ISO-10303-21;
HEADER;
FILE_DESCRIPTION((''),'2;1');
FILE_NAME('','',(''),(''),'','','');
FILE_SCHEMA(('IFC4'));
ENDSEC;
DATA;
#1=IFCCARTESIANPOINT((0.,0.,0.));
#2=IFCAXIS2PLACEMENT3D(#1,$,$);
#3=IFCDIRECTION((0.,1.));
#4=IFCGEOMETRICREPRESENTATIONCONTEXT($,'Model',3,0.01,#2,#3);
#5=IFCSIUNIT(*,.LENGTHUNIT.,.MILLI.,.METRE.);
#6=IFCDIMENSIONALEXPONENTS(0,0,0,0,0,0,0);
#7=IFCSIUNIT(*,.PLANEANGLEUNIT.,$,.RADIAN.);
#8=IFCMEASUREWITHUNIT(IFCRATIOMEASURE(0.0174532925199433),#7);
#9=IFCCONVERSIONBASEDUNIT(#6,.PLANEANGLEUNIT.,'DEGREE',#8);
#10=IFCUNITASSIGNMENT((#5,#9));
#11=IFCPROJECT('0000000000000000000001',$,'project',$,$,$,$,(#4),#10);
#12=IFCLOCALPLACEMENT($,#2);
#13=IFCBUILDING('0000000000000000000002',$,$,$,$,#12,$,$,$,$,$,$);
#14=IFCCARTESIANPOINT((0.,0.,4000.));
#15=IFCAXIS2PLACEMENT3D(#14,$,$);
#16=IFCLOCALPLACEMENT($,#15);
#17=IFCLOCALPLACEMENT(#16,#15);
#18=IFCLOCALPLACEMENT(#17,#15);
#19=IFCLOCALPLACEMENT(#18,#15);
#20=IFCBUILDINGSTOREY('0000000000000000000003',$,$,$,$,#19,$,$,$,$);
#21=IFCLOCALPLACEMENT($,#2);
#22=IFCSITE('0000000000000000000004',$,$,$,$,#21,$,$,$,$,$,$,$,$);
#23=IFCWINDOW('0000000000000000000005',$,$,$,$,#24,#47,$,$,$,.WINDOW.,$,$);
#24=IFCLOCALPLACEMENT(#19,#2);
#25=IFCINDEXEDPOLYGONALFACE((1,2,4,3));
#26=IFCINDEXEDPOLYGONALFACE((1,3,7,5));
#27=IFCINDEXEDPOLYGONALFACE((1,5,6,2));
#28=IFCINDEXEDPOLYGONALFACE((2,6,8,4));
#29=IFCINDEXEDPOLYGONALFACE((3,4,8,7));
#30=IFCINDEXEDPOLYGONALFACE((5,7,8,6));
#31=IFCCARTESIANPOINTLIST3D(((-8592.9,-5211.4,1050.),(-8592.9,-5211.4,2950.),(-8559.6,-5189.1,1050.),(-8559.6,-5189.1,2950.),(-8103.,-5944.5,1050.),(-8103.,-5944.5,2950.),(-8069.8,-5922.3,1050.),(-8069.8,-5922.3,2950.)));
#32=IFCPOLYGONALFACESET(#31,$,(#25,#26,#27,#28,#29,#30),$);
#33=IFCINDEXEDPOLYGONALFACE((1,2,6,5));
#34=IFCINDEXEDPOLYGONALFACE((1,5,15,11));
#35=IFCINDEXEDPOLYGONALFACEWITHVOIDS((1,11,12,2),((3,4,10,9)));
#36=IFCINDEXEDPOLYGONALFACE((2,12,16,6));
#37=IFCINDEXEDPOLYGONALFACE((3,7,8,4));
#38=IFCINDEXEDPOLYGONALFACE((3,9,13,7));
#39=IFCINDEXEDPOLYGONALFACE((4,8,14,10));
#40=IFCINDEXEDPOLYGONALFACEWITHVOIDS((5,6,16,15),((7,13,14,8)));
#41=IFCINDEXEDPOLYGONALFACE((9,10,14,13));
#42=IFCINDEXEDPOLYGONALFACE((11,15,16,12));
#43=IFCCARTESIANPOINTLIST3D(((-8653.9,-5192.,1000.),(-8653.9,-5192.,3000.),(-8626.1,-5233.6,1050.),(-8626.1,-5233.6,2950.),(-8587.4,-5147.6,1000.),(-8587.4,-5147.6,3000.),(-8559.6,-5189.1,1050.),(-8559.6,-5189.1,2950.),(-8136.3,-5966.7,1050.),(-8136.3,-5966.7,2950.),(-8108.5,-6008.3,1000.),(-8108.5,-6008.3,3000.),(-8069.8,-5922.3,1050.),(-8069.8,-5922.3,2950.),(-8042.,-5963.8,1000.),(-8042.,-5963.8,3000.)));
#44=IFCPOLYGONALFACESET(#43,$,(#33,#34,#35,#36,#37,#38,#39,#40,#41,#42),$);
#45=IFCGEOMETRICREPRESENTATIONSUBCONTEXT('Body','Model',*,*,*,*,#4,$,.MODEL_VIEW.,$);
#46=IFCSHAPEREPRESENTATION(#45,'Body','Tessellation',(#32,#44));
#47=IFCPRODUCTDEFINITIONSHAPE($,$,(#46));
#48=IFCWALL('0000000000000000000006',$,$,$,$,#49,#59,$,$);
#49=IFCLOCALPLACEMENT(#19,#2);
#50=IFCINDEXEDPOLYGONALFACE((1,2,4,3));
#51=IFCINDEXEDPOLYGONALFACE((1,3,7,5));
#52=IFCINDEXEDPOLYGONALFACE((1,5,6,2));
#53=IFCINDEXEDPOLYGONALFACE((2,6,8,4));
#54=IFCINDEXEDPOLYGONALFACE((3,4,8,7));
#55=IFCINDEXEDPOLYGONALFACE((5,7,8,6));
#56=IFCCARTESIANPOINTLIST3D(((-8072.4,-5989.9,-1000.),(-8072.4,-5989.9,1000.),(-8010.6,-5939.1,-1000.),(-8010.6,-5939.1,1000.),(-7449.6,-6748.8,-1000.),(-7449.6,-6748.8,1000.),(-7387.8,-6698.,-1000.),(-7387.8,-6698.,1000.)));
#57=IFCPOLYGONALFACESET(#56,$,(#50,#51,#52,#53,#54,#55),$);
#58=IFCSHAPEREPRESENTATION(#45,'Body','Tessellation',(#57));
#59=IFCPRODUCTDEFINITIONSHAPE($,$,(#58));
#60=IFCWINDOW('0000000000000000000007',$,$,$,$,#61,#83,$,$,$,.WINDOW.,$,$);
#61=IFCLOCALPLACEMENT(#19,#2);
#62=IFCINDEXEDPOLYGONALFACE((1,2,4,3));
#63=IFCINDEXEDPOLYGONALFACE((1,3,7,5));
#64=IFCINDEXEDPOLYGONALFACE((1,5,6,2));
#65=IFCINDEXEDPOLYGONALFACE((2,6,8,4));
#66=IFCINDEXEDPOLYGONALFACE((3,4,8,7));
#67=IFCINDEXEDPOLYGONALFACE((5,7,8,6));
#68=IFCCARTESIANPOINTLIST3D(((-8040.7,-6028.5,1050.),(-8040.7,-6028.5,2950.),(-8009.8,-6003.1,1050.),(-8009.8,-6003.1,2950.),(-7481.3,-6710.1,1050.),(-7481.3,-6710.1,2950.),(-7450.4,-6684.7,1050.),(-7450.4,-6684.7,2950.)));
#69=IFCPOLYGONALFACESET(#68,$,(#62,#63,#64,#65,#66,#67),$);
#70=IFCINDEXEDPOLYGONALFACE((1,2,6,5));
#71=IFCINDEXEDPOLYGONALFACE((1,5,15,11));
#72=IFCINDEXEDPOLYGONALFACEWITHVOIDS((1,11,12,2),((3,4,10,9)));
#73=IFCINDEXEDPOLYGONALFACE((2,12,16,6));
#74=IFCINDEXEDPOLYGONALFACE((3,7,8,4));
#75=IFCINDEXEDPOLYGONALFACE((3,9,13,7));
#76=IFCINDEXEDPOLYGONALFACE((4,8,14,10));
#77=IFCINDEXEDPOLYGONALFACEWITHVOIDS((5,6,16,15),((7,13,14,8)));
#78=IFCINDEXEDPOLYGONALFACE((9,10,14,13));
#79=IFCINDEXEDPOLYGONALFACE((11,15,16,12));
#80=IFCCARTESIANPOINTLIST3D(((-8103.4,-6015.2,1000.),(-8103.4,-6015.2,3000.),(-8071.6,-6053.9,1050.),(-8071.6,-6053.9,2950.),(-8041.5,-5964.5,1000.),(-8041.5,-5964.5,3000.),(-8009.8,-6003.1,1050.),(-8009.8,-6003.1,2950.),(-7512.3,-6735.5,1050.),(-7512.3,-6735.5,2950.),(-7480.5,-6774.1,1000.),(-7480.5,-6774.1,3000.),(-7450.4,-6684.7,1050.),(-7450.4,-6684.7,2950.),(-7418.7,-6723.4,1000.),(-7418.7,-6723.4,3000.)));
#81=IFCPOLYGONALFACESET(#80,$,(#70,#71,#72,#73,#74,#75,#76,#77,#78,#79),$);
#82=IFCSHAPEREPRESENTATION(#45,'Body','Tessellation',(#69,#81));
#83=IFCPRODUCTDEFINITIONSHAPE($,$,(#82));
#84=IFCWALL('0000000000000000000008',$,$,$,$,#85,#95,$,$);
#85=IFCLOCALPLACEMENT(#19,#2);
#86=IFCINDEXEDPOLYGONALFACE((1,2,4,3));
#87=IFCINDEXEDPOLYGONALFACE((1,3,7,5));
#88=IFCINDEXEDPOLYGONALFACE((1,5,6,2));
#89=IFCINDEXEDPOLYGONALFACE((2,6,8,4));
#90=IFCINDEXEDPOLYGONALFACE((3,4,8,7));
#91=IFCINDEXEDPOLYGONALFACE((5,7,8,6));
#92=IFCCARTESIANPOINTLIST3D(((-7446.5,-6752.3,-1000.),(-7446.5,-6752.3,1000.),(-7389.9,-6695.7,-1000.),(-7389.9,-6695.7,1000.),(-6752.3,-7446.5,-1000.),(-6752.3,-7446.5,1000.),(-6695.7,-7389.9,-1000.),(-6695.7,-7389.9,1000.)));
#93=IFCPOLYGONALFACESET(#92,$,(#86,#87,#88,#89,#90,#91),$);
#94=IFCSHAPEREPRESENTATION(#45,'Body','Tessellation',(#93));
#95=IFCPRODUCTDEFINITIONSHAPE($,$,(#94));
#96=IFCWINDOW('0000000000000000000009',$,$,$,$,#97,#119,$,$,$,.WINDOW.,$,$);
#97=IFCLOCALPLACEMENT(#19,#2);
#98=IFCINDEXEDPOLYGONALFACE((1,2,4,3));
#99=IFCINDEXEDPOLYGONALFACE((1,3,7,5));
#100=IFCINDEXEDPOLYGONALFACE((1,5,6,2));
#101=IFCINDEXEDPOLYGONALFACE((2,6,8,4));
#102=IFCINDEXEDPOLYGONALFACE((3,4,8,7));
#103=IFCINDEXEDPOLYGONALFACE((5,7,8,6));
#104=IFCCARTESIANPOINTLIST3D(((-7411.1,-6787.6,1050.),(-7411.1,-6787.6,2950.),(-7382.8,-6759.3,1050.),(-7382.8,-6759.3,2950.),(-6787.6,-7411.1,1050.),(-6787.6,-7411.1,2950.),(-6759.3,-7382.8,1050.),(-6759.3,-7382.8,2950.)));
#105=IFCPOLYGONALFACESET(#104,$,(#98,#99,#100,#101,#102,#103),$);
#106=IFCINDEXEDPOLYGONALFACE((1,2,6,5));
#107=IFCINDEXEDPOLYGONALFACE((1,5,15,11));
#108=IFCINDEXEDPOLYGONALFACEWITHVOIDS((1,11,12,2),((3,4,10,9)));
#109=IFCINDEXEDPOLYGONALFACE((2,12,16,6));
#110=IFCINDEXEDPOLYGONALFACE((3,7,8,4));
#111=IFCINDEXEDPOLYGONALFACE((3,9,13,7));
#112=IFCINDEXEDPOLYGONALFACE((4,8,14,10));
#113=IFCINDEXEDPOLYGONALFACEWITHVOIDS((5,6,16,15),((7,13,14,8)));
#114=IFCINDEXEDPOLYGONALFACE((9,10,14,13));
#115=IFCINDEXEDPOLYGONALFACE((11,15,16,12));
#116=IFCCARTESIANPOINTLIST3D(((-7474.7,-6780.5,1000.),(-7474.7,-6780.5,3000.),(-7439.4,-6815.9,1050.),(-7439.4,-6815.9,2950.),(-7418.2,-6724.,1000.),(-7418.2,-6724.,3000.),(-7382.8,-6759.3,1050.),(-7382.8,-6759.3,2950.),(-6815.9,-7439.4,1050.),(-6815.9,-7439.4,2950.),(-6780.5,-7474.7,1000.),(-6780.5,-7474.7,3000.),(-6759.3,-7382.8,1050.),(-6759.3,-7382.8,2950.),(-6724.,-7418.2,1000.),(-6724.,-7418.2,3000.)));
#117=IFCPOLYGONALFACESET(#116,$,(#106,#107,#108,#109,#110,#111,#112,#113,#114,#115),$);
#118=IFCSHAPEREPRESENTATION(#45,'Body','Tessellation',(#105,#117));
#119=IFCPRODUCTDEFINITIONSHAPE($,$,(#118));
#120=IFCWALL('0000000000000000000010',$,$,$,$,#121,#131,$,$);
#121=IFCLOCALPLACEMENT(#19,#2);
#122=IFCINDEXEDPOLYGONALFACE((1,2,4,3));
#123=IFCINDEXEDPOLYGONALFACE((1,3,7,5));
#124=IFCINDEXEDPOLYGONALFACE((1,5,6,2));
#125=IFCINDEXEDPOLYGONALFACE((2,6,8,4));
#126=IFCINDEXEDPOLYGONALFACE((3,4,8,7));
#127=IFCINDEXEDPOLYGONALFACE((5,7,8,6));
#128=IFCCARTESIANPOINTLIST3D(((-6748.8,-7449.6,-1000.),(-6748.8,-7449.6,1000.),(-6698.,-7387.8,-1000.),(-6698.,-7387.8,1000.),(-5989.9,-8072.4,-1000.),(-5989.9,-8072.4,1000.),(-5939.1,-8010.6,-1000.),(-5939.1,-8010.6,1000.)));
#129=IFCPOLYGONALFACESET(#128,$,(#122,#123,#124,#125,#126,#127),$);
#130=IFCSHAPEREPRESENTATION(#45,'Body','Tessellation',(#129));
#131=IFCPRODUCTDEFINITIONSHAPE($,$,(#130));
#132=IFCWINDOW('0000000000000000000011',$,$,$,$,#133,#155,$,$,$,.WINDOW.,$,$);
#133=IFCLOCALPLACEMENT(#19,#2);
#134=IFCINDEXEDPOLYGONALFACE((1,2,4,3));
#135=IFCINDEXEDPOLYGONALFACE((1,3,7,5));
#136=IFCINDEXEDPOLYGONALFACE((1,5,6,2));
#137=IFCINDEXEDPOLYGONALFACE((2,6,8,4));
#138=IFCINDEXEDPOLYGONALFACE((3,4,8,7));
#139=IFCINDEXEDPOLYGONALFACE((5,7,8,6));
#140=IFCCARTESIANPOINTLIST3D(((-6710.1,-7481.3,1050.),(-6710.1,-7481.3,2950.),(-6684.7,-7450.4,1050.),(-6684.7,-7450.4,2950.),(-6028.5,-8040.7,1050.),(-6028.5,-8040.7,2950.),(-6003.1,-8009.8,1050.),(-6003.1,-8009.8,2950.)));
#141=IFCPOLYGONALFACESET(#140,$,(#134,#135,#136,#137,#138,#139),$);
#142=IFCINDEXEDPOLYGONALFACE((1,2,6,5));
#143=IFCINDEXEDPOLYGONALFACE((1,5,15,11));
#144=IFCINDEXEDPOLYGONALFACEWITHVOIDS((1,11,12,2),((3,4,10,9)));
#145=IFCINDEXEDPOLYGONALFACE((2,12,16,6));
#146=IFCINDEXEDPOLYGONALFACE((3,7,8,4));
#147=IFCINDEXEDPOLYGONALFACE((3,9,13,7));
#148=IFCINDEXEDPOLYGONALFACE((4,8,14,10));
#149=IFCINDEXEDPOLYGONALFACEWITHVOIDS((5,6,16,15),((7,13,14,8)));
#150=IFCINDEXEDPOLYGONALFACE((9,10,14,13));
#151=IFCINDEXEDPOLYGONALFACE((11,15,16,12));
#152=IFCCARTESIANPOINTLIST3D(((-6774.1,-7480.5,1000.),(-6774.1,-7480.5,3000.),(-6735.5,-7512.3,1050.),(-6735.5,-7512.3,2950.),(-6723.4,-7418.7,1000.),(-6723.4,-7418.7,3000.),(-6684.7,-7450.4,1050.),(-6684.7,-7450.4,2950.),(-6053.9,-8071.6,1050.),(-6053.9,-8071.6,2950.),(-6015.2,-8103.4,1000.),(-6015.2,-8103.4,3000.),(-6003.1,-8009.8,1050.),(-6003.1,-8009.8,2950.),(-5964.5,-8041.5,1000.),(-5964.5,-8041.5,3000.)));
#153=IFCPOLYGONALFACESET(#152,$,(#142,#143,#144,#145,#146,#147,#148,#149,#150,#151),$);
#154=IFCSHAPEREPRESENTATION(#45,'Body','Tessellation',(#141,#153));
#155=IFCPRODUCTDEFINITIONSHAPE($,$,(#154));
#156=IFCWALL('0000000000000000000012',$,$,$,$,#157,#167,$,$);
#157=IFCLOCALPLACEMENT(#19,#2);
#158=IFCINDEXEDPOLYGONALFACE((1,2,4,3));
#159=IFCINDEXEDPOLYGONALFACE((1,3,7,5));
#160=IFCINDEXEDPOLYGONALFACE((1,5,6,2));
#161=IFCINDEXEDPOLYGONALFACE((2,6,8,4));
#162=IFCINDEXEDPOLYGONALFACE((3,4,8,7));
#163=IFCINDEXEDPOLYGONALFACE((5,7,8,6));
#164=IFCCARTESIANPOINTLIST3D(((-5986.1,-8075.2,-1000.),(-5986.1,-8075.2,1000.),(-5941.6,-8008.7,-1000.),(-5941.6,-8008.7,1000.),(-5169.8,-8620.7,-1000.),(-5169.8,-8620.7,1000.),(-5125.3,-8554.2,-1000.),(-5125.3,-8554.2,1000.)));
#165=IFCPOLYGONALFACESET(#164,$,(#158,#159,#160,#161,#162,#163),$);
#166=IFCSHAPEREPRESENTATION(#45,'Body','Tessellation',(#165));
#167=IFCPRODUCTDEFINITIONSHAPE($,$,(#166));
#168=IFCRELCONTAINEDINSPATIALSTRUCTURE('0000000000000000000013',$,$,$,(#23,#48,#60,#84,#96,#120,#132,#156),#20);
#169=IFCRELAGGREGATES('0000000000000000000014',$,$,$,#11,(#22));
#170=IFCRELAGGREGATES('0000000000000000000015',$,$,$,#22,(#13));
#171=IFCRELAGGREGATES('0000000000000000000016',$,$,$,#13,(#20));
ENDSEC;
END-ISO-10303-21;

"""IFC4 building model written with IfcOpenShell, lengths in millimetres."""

from ifc_helpers import new_model, entity, si_unit, converted_unit, direction, frame, origin, origin_2d, place, context, subcontext, project, spatial, rectangle, extrude, element, save


model = new_model("IFC4")

# Units and contexts
model_context = context("Model", 3, precision=0.01, world=origin(), true_north=direction((0.0, 1.0)))
body_context = subcontext(model_context, "Body", "Model", "MODEL_VIEW")
ifc_project = project(units=[si_unit("LENGTHUNIT", "METRE", prefix="MILLI"), converted_unit("PLANEANGLEUNIT", "DEGREE", entity("IfcRatioMeasure", 0.0174532925199433), si_unit("PLANEANGLEUNIT", "RADIAN"), dimensions=[0, 0, 0, 0, 0, 0, 0])], contexts=[model_context])

# Site, building, storey
site_placement = place(None, origin())
site = spatial("IfcSite", under=ifc_project, at=site_placement)
building_placement = place(None, origin())
building = spatial("IfcBuilding", under=site, at=building_placement)
placement_1 = place(None, frame((0.0, 0.0, 4000.0)))
placement_2 = place(placement_1, frame((0.0, 0.0, 4000.0)))
placement_3 = place(placement_2, frame((0.0, 0.0, 4000.0)))
storey_placement = place(placement_3, frame((0.0, 0.0, 4000.0)))
storey = spatial("IfcBuildingStorey", under=building, at=storey_placement)

# Shared definitions
cartesian_point_1 = entity("IfcCartesianPoint", [-440.9, -950.0])
shared_polyline = entity("IfcPolyline", [cartesian_point_1, entity("IfcCartesianPoint", [-440.9, 950.0]), entity("IfcCartesianPoint", [-440.9, 950.0]), entity("IfcCartesianPoint", [440.9, 950.0]), entity("IfcCartesianPoint", [440.9, 950.0]), entity("IfcCartesianPoint", [440.9, -950.0]), entity("IfcCartesianPoint", [440.9, -950.0]), entity("IfcCartesianPoint", [-440.9, -950.0]), cartesian_point_1])

# Window
window_1_placement = place(storey_placement, frame((-8314.7, -5555.7, 2000.0), z_axis=(0.0, 0.0, 1.0), x_axis=(5555.703069, -8314.695629, 0.0)))
cartesian_point_2 = entity("IfcCartesianPoint", [-490.9, -1000.0])
element("IfcWindow", 1, at=window_1_placement, inside=storey, PredefinedType="WINDOW", context=body_context, shape_type="SweptSolid", body=[
    entity("IfcExtrudedAreaSolid", entity("IfcArbitraryClosedProfileDef", "AREA", None, shared_polyline), entity("IfcAxis2Placement3D", entity("IfcCartesianPoint", [0.0, 0.0, 0.0]), entity("IfcDirection", [0.0, -1.0, 0.0]), entity("IfcDirection", [1.0, 0.0, 0.0])), entity("IfcDirection", [0.0, 0.0, 1.0]), 40.0),
    entity("IfcExtrudedAreaSolid", entity("IfcArbitraryProfileDefWithVoids", "AREA", None, entity("IfcPolyline", [cartesian_point_2, entity("IfcCartesianPoint", [-490.9, 1000.0]), entity("IfcCartesianPoint", [-490.9, 1000.0]), entity("IfcCartesianPoint", [490.9, 1000.0]), entity("IfcCartesianPoint", [490.9, 1000.0]), entity("IfcCartesianPoint", [490.9, -1000.0]), entity("IfcCartesianPoint", [490.9, -1000.0]), entity("IfcCartesianPoint", [-490.9, -1000.0]), cartesian_point_2]), [shared_polyline]), entity("IfcAxis2Placement3D", entity("IfcCartesianPoint", [0.0, 0.0, 0.0]), entity("IfcDirection", [0.0, -1.0, 0.0]), entity("IfcDirection", [1.0, 0.0, 0.0])), entity("IfcDirection", [0.0, 0.0, 1.0]), 80.0),
])

# Wall
wall_1_placement = place(storey_placement, frame((-7730.1, -6343.9, -1000.0), z_axis=(0.0, 0.0, 1.0), x_axis=(6343.931995, -7730.105228, 0.0)))
element("IfcWall", 2, at=wall_1_placement, inside=storey, context=body_context, shape_type="SweptSolid", body=[
    extrude(rectangle(XDim=981.7, YDim=80.0, at=origin_2d()), origin(), (0.0, 0.0, 1.0), 2000.0),
])

# Window
window_2_placement = place(storey_placement, frame((-7730.1, -6343.9, 2000.0), z_axis=(0.0, 0.0, 1.0), x_axis=(6343.931995, -7730.105228, 0.0)))
cartesian_point_3 = entity("IfcCartesianPoint", [-490.9, -1000.0])
element("IfcWindow", 3, at=window_2_placement, inside=storey, PredefinedType="WINDOW", context=body_context, shape_type="SweptSolid", body=[
    entity("IfcExtrudedAreaSolid", entity("IfcArbitraryClosedProfileDef", "AREA", None, shared_polyline), entity("IfcAxis2Placement3D", entity("IfcCartesianPoint", [0.0, 0.0, 0.0]), entity("IfcDirection", [0.0, -1.0, 0.0]), entity("IfcDirection", [1.0, 0.0, 0.0])), entity("IfcDirection", [0.0, 0.0, 1.0]), 40.0),
    entity("IfcExtrudedAreaSolid", entity("IfcArbitraryProfileDefWithVoids", "AREA", None, entity("IfcPolyline", [cartesian_point_3, entity("IfcCartesianPoint", [-490.9, 1000.0]), entity("IfcCartesianPoint", [-490.9, 1000.0]), entity("IfcCartesianPoint", [490.9, 1000.0]), entity("IfcCartesianPoint", [490.9, 1000.0]), entity("IfcCartesianPoint", [490.9, -1000.0]), entity("IfcCartesianPoint", [490.9, -1000.0]), entity("IfcCartesianPoint", [-490.9, -1000.0]), cartesian_point_3]), [shared_polyline]), entity("IfcAxis2Placement3D", entity("IfcCartesianPoint", [0.0, 0.0, 0.0]), entity("IfcDirection", [0.0, -1.0, 0.0]), entity("IfcDirection", [1.0, 0.0, 0.0])), entity("IfcDirection", [0.0, 0.0, 1.0]), 80.0),
])

# Wall
wall_2_placement = place(storey_placement, frame((-7071.1, -7071.1, -1000.0), z_axis=(0.0, 0.0, 1.0), x_axis=(7071.06732, -7071.068304, 0.0)))
element("IfcWall", 4, at=wall_2_placement, inside=storey, context=body_context, shape_type="SweptSolid", body=[
    extrude(rectangle(XDim=981.7, YDim=80.0, at=origin_2d()), origin(), (0.0, 0.0, 1.0), 2000.0),
])

# Window
window_3_placement = place(storey_placement, frame((-7071.1, -7071.1, 2000.0), z_axis=(0.0, 0.0, 1.0), x_axis=(7071.06732, -7071.068304, 0.0)))
cartesian_point_4 = entity("IfcCartesianPoint", [-490.9, -1000.0])
element("IfcWindow", 5, at=window_3_placement, inside=storey, PredefinedType="WINDOW", context=body_context, shape_type="SweptSolid", body=[
    entity("IfcExtrudedAreaSolid", entity("IfcArbitraryClosedProfileDef", "AREA", None, shared_polyline), entity("IfcAxis2Placement3D", entity("IfcCartesianPoint", [0.0, 0.0, 0.0]), entity("IfcDirection", [0.0, -1.0, 0.0]), entity("IfcDirection", [1.0, 0.0, 0.0])), entity("IfcDirection", [0.0, 0.0, 1.0]), 40.0),
    entity("IfcExtrudedAreaSolid", entity("IfcArbitraryProfileDefWithVoids", "AREA", None, entity("IfcPolyline", [cartesian_point_4, entity("IfcCartesianPoint", [-490.9, 1000.0]), entity("IfcCartesianPoint", [-490.9, 1000.0]), entity("IfcCartesianPoint", [490.9, 1000.0]), entity("IfcCartesianPoint", [490.9, 1000.0]), entity("IfcCartesianPoint", [490.9, -1000.0]), entity("IfcCartesianPoint", [490.9, -1000.0]), entity("IfcCartesianPoint", [-490.9, -1000.0]), cartesian_point_4]), [shared_polyline]), entity("IfcAxis2Placement3D", entity("IfcCartesianPoint", [0.0, 0.0, 0.0]), entity("IfcDirection", [0.0, -1.0, 0.0]), entity("IfcDirection", [1.0, 0.0, 0.0])), entity("IfcDirection", [0.0, 0.0, 1.0]), 80.0),
])

# Wall
wall_3_placement = place(storey_placement, frame((-6343.9, -7730.1, -1000.0), z_axis=(0.0, 0.0, 1.0), x_axis=(7730.104346, -6343.93307, 0.0)))
element("IfcWall", 6, at=wall_3_placement, inside=storey, context=body_context, shape_type="SweptSolid", body=[
    extrude(rectangle(XDim=981.7, YDim=80.0, at=origin_2d()), origin(), (0.0, 0.0, 1.0), 2000.0),
])

# Window
window_4_placement = place(storey_placement, frame((-6343.9, -7730.1, 2000.0), z_axis=(0.0, 0.0, 1.0), x_axis=(7730.104346, -6343.93307, 0.0)))
cartesian_point_5 = entity("IfcCartesianPoint", [-490.9, -1000.0])
element("IfcWindow", 7, at=window_4_placement, inside=storey, PredefinedType="WINDOW", context=body_context, shape_type="SweptSolid", body=[
    entity("IfcExtrudedAreaSolid", entity("IfcArbitraryClosedProfileDef", "AREA", None, shared_polyline), entity("IfcAxis2Placement3D", entity("IfcCartesianPoint", [0.0, 0.0, 0.0]), entity("IfcDirection", [0.0, -1.0, 0.0]), entity("IfcDirection", [1.0, 0.0, 0.0])), entity("IfcDirection", [0.0, 0.0, 1.0]), 40.0),
    entity("IfcExtrudedAreaSolid", entity("IfcArbitraryProfileDefWithVoids", "AREA", None, entity("IfcPolyline", [cartesian_point_5, entity("IfcCartesianPoint", [-490.9, 1000.0]), entity("IfcCartesianPoint", [-490.9, 1000.0]), entity("IfcCartesianPoint", [490.9, 1000.0]), entity("IfcCartesianPoint", [490.9, 1000.0]), entity("IfcCartesianPoint", [490.9, -1000.0]), entity("IfcCartesianPoint", [490.9, -1000.0]), entity("IfcCartesianPoint", [-490.9, -1000.0]), cartesian_point_5]), [shared_polyline]), entity("IfcAxis2Placement3D", entity("IfcCartesianPoint", [0.0, 0.0, 0.0]), entity("IfcDirection", [0.0, -1.0, 0.0]), entity("IfcDirection", [1.0, 0.0, 0.0])), entity("IfcDirection", [0.0, 0.0, 1.0]), 80.0),
])

# Wall
wall_4_placement = place(storey_placement, frame((-5555.7, -8314.7, -1000.0), z_axis=(0.0, 0.0, 1.0), x_axis=(8314.694856, -5555.704226, 0.0)))
element("IfcWall", 8, at=wall_4_placement, inside=storey, context=body_context, shape_type="SweptSolid", body=[
    extrude(rectangle(XDim=981.7, YDim=80.0, at=origin_2d()), origin(), (0.0, 0.0, 1.0), 2000.0),
])

save(model, "model.ifc")
